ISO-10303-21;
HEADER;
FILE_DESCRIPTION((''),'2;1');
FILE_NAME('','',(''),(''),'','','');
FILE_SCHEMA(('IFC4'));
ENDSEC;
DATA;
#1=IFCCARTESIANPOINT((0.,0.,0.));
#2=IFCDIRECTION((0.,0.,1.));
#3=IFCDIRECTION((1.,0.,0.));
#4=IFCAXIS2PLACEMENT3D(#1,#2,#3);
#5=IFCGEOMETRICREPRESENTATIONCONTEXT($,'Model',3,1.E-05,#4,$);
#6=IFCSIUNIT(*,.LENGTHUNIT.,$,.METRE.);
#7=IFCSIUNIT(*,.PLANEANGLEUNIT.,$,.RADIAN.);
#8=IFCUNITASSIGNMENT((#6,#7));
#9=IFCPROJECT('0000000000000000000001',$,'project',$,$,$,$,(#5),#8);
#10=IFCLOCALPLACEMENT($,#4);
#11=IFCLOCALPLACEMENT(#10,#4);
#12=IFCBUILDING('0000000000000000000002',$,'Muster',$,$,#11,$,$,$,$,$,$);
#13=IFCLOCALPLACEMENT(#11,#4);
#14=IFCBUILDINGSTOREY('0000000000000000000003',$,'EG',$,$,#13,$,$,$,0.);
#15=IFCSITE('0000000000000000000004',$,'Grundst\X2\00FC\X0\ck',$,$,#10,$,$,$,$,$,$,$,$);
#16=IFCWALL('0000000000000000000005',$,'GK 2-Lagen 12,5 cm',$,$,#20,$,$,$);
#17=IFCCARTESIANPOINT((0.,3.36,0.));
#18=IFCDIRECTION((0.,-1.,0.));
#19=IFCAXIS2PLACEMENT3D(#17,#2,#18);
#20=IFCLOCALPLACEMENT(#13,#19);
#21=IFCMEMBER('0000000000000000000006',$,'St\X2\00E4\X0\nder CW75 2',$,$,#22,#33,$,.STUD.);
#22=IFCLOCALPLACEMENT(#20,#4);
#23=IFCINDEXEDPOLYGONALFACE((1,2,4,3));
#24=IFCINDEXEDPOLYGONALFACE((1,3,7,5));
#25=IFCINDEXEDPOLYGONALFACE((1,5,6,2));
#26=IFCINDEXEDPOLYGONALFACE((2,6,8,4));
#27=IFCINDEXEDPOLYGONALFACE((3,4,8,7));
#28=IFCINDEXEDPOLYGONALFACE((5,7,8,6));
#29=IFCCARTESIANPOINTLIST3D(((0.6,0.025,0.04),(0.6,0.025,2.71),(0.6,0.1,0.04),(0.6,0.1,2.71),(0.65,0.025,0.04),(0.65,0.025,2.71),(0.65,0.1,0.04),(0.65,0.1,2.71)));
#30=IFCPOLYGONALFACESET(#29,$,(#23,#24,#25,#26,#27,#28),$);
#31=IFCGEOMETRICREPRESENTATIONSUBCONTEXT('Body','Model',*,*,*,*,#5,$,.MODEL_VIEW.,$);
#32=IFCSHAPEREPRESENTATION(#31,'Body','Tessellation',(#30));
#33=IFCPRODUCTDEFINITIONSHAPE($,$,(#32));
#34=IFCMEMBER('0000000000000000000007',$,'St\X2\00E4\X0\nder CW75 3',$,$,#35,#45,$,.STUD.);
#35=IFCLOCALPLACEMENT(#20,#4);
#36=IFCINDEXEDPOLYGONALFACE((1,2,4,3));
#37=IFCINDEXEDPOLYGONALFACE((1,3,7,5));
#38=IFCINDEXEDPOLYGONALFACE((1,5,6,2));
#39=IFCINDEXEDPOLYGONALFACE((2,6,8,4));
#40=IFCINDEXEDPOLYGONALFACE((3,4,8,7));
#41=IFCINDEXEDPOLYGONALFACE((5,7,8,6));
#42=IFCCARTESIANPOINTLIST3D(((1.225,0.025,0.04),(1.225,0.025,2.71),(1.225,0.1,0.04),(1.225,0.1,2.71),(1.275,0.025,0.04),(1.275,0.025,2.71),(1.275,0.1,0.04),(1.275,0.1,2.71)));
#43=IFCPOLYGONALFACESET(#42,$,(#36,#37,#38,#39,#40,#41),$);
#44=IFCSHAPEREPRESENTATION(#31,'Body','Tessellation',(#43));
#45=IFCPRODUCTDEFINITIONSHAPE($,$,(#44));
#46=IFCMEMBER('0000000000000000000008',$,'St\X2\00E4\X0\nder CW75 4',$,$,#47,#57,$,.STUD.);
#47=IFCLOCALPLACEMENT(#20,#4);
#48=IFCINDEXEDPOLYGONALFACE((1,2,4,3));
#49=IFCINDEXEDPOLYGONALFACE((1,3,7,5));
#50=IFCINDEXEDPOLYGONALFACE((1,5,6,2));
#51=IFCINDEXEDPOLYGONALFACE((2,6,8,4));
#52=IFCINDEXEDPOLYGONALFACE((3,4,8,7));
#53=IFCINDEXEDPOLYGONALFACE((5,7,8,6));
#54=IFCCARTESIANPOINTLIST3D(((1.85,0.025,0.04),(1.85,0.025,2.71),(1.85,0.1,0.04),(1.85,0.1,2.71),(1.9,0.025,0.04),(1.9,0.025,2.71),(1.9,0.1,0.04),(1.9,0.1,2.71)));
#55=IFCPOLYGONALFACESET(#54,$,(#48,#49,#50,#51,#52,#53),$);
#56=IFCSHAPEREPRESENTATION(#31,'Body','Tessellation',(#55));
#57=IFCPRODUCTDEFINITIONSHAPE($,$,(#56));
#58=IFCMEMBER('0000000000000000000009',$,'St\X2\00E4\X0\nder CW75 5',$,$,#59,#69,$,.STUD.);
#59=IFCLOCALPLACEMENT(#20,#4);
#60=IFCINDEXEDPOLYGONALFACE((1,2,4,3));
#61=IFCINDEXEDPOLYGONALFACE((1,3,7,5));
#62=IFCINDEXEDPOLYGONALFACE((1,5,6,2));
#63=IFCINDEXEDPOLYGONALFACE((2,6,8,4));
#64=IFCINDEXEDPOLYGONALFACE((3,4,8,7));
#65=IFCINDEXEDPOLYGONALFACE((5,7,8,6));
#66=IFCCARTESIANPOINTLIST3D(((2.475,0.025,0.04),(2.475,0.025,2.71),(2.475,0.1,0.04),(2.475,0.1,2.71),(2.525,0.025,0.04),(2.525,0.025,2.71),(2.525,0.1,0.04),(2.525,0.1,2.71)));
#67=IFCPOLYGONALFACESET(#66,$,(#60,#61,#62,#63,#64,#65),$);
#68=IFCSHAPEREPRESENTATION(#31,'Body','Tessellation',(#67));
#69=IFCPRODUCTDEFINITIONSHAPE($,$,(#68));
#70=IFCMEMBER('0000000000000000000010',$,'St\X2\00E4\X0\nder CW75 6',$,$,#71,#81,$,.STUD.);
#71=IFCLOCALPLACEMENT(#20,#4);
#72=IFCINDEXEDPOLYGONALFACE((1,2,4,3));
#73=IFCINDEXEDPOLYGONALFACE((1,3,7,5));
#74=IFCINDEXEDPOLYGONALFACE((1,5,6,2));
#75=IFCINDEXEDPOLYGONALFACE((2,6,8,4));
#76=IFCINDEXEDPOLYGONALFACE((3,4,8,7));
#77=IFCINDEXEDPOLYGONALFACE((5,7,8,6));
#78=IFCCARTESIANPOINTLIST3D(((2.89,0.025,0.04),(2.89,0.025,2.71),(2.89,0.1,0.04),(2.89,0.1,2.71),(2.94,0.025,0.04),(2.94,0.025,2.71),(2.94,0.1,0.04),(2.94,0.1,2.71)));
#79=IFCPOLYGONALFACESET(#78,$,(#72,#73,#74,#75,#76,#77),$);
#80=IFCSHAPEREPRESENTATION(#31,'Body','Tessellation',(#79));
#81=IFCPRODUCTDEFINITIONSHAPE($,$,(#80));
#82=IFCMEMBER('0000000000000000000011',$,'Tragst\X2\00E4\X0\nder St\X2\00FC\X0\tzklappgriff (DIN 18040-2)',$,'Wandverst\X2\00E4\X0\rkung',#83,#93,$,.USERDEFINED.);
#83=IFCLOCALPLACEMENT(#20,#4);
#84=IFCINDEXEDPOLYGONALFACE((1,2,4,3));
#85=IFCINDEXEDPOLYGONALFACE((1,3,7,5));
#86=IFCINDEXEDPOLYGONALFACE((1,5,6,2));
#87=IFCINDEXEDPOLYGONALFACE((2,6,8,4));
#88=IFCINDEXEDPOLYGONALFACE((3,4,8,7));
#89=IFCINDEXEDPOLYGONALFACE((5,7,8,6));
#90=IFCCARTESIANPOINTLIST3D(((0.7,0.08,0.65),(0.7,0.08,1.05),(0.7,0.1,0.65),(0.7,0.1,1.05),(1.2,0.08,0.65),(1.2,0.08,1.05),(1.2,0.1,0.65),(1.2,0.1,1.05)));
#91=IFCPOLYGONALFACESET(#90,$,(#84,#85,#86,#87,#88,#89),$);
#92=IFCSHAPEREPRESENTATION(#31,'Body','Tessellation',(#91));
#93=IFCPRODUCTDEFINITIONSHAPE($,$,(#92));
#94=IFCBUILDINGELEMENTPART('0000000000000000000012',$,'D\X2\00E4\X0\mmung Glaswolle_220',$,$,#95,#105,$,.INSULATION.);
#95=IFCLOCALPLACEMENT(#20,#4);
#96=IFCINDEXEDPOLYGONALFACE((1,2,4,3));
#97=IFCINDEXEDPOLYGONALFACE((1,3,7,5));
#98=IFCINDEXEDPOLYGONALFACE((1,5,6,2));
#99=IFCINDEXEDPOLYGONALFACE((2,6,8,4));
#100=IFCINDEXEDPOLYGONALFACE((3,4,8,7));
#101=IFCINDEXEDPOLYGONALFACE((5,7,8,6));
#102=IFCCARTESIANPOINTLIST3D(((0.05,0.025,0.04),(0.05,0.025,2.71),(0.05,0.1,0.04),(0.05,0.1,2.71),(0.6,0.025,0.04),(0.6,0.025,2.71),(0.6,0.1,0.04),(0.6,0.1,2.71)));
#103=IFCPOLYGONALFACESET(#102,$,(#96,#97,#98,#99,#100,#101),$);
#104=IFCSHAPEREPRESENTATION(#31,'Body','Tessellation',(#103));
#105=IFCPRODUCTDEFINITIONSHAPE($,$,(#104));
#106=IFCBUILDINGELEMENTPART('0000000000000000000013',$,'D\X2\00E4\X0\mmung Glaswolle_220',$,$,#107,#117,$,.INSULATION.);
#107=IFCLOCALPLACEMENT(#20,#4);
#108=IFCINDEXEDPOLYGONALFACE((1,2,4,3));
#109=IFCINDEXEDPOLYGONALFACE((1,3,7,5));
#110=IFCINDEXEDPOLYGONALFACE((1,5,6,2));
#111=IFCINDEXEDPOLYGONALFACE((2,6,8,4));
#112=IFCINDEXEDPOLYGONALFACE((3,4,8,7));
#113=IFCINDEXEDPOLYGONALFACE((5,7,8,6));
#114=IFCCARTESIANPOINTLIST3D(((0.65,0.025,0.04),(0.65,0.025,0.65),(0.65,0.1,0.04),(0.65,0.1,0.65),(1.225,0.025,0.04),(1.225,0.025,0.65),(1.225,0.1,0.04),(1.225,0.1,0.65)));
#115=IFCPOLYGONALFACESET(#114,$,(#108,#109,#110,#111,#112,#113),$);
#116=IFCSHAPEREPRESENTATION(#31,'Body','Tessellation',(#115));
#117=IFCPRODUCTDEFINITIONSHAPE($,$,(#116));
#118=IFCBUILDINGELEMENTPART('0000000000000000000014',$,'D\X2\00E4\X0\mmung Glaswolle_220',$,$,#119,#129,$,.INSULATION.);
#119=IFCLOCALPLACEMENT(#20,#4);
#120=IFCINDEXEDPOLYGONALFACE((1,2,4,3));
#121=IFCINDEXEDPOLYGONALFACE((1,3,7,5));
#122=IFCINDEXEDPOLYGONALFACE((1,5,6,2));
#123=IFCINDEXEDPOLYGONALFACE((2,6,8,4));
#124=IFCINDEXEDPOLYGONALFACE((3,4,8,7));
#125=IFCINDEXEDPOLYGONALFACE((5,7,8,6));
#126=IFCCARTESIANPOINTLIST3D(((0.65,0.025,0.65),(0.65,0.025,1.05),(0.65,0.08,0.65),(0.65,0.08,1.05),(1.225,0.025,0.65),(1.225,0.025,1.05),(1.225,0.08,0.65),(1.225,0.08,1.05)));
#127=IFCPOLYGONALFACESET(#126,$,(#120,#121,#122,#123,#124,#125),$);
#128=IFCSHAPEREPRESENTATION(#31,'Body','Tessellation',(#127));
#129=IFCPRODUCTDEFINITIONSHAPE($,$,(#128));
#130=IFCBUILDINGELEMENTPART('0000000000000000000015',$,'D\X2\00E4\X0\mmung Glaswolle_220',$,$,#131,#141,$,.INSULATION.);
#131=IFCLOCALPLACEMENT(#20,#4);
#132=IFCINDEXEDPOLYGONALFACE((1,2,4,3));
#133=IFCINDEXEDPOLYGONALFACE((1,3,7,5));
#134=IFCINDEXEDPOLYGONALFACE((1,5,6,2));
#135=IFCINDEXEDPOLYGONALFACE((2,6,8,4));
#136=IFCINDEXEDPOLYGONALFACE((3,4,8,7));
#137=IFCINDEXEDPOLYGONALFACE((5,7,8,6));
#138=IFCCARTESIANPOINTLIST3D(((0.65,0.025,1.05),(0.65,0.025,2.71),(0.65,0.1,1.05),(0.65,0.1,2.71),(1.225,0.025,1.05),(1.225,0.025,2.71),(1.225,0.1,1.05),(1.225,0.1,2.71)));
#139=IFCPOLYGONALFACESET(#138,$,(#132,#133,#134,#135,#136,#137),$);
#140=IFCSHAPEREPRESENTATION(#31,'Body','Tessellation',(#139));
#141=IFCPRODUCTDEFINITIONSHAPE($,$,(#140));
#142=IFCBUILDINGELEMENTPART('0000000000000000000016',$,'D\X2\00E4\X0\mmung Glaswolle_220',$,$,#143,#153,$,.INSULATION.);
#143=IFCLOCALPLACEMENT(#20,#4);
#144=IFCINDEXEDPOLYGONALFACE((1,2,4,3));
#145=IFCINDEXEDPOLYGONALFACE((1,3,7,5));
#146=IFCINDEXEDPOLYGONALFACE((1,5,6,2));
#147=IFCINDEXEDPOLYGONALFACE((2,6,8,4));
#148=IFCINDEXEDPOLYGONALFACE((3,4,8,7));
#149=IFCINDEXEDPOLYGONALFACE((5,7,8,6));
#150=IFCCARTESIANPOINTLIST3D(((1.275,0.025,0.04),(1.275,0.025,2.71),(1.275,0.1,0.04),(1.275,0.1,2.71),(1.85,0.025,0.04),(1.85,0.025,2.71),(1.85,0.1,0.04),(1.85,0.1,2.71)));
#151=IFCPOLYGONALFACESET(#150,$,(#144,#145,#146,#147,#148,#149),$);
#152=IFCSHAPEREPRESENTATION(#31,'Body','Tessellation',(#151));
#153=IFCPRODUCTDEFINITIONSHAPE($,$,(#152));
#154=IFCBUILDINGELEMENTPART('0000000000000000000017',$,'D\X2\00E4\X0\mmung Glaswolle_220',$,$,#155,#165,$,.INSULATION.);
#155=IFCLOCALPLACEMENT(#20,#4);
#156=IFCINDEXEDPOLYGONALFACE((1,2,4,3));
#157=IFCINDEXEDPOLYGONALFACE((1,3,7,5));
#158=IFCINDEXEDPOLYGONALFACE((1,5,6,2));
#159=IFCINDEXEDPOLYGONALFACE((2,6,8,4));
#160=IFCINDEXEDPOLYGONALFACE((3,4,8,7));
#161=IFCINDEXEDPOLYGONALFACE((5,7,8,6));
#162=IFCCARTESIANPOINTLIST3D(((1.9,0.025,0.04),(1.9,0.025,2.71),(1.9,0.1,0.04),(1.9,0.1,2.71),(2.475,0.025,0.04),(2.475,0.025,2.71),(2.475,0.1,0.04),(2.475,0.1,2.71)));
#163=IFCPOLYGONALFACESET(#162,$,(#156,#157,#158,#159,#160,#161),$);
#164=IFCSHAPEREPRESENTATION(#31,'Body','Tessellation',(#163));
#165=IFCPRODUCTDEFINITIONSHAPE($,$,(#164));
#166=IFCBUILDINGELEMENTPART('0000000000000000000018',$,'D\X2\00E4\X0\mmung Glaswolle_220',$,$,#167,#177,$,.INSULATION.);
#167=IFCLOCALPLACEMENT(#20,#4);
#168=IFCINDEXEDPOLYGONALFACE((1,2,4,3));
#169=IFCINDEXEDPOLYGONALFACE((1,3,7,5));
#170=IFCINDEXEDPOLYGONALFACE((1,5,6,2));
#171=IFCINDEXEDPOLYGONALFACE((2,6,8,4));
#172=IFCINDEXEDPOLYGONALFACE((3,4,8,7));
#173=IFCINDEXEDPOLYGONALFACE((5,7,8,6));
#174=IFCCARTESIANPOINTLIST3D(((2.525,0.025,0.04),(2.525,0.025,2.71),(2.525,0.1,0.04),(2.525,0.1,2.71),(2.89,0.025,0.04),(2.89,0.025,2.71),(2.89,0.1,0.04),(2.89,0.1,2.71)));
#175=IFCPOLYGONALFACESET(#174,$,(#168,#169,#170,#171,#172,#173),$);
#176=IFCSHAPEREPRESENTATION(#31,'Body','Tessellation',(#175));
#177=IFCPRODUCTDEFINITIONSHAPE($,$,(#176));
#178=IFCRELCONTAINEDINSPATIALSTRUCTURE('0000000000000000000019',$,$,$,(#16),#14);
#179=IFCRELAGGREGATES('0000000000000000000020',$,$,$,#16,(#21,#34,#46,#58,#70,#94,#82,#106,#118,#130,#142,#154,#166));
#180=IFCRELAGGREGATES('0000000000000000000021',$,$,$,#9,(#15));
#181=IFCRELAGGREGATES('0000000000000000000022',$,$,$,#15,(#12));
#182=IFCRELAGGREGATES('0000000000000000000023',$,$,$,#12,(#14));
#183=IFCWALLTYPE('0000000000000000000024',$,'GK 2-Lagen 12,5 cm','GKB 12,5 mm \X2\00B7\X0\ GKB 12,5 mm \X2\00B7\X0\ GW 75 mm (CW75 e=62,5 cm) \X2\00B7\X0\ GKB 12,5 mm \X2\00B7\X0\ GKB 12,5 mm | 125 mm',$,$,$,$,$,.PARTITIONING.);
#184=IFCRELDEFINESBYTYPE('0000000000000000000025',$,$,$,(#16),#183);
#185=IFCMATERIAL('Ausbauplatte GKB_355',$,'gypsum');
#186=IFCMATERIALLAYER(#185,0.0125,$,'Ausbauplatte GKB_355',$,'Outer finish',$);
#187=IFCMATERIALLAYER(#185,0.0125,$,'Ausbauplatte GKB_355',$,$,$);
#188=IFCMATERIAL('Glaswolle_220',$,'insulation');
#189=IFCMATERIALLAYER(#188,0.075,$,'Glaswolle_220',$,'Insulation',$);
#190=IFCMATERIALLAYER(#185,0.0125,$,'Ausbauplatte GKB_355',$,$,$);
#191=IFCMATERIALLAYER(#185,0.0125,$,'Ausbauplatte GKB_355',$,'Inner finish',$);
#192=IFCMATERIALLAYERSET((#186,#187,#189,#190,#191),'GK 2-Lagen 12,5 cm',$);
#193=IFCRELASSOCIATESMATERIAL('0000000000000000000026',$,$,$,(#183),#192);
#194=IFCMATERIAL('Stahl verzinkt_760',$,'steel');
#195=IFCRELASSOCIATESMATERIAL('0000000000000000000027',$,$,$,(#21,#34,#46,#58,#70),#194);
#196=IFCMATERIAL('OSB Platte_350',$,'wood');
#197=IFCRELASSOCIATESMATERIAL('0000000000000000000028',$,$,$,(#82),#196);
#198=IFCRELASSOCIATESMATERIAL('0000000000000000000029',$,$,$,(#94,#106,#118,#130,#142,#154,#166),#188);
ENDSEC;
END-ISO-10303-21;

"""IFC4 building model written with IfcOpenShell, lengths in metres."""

from ifc_helpers import new_model, si_unit, frame, frame_2d, origin_with_axes, place, context, subcontext, project, spatial, rectangle, extrude, material, layer, layer_set, type_object, element, aggregate, save


model = new_model("IFC4")

# Units and contexts
model_context = context("Model", 3, precision=1e-05, world=origin_with_axes())
body_context = subcontext(model_context, "Body", "Model", "MODEL_VIEW")
ifc_project = project(units=[si_unit("LENGTHUNIT", "METRE"), si_unit("PLANEANGLEUNIT", "RADIAN")], contexts=[model_context])

# Site, building, storey
site_placement = place(None, origin_with_axes())
site = spatial("IfcSite", under=ifc_project, at=site_placement, Name="Grundstück")
building_placement = place(site_placement, origin_with_axes())
building = spatial("IfcBuilding", under=site, at=building_placement, Name="Muster")
storey_placement = place(building_placement, origin_with_axes())
storey = spatial("IfcBuildingStorey", under=building, at=storey_placement, Name="EG", Elevation=0.0)

# Wall, members
ifc_material_1 = material(Name="Ausbauplatte GKB_355", Category="gypsum")
ifc_layer_1 = layer(ifc_material_1, 0.0125, Name="Ausbauplatte GKB_355", Category="Outer finish")
ifc_layer_2 = layer(ifc_material_1, 0.0125, Name="Ausbauplatte GKB_355")
ifc_material_2 = material(Name="Glaswolle_220", Category="insulation")
ifc_layer_3 = layer(ifc_material_2, 0.075, Name="Glaswolle_220", Category="Insulation")
ifc_layer_4 = layer(ifc_material_1, 0.0125, Name="Ausbauplatte GKB_355")
ifc_layer_5 = layer(ifc_material_1, 0.0125, Name="Ausbauplatte GKB_355", Category="Inner finish")
ifc_layer_set_1 = layer_set([ifc_layer_1, ifc_layer_2, ifc_layer_3, ifc_layer_4, ifc_layer_5], Name="GK 2-Lagen 12,5 cm")
wall_type_1 = type_object("IfcWallType", Name="GK 2-Lagen 12,5 cm", Description="GKB 12,5 mm · GKB 12,5 mm · GW 75 mm (CW75 e=62,5 cm) · GKB 12,5 mm · GKB 12,5 mm | 125 mm", PredefinedType="PARTITIONING", material=ifc_layer_set_1)
wall_1_placement = place(storey_placement, frame((0.0, 3.36, 0.0), z_axis=(0.0, 0.0, 1.0), x_axis=(0.0, -1.0, 0.0)))
wall_1 = element("IfcWall", 1, at=wall_1_placement, inside=storey, type_object=wall_type_1, Name="GK 2-Lagen 12,5 cm")
ifc_material_3 = material(Name="Stahl verzinkt_760", Category="steel")
member_1_placement = place(wall_1_placement, origin_with_axes())
member_1 = element("IfcMember", 2, at=member_1_placement, material=ifc_material_3, Name="Ständer CW75 2", PredefinedType="STUD", context=body_context, shape_type="SweptSolid", body=[
    extrude(rectangle(XDim=0.05, YDim=0.075, at=frame_2d((0.625, 0.0625))), frame((0.0, 0.0, 0.04)), (0.0, 0.0, 1.0), 2.67),
])
member_2_placement = place(wall_1_placement, origin_with_axes())
member_2 = element("IfcMember", 3, at=member_2_placement, material=ifc_material_3, Name="Ständer CW75 3", PredefinedType="STUD", context=body_context, shape_type="SweptSolid", body=[
    extrude(rectangle(XDim=0.05, YDim=0.075, at=frame_2d((1.25, 0.0625))), frame((0.0, 0.0, 0.04)), (0.0, 0.0, 1.0), 2.67),
])
member_3_placement = place(wall_1_placement, origin_with_axes())
member_3 = element("IfcMember", 4, at=member_3_placement, material=ifc_material_3, Name="Ständer CW75 4", PredefinedType="STUD", context=body_context, shape_type="SweptSolid", body=[
    extrude(rectangle(XDim=0.05, YDim=0.075, at=frame_2d((1.875, 0.0625))), frame((0.0, 0.0, 0.04)), (0.0, 0.0, 1.0), 2.67),
])
member_4_placement = place(wall_1_placement, origin_with_axes())
member_4 = element("IfcMember", 5, at=member_4_placement, material=ifc_material_3, Name="Ständer CW75 5", PredefinedType="STUD", context=body_context, shape_type="SweptSolid", body=[
    extrude(rectangle(XDim=0.05, YDim=0.075, at=frame_2d((2.5, 0.0625))), frame((0.0, 0.0, 0.04)), (0.0, 0.0, 1.0), 2.67),
])
member_5_placement = place(wall_1_placement, origin_with_axes())
member_5 = element("IfcMember", 6, at=member_5_placement, material=ifc_material_3, Name="Ständer CW75 6", PredefinedType="STUD", context=body_context, shape_type="SweptSolid", body=[
    extrude(rectangle(XDim=0.05, YDim=0.075, at=frame_2d((2.915, 0.0625))), frame((0.0, 0.0, 0.04)), (0.0, 0.0, 1.0), 2.67),
])
ifc_material_4 = material(Name="OSB Platte_350", Category="wood")
member_6_placement = place(wall_1_placement, origin_with_axes())
member_6 = element("IfcMember", 7, at=member_6_placement, material=ifc_material_4, Name="Tragständer Stützklappgriff (DIN 18040-2)", ObjectType="Wandverstärkung", PredefinedType="USERDEFINED", context=body_context, shape_type="SweptSolid", body=[
    extrude(rectangle(XDim=0.5, YDim=0.02, at=frame_2d((0.95, 0.09))), frame((0.0, 0.0, 0.65)), (0.0, 0.0, 1.0), 0.4),
])

# Building element parts
building_element_part_1_placement = place(wall_1_placement, origin_with_axes())
building_element_part_1 = element("IfcBuildingElementPart", 8, at=building_element_part_1_placement, material=ifc_material_2, Name="Dämmung Glaswolle_220", PredefinedType="INSULATION", context=body_context, shape_type="SweptSolid", body=[
    extrude(rectangle(XDim=0.55, YDim=0.075, at=frame_2d((0.325, 0.0625))), frame((0.0, 0.0, 0.04)), (0.0, 0.0, 1.0), 2.67),
])
building_element_part_2_placement = place(wall_1_placement, origin_with_axes())
building_element_part_2 = element("IfcBuildingElementPart", 9, at=building_element_part_2_placement, material=ifc_material_2, Name="Dämmung Glaswolle_220", PredefinedType="INSULATION", context=body_context, shape_type="SweptSolid", body=[
    extrude(rectangle(XDim=0.575, YDim=0.075, at=frame_2d((0.9375, 0.0625))), frame((0.0, 0.0, 0.04)), (0.0, 0.0, 1.0), 0.61),
])
building_element_part_3_placement = place(wall_1_placement, origin_with_axes())
building_element_part_3 = element("IfcBuildingElementPart", 10, at=building_element_part_3_placement, material=ifc_material_2, Name="Dämmung Glaswolle_220", PredefinedType="INSULATION", context=body_context, shape_type="SweptSolid", body=[
    extrude(rectangle(XDim=0.575, YDim=0.055, at=frame_2d((0.9375, 0.0525))), frame((0.0, 0.0, 0.65)), (0.0, 0.0, 1.0), 0.4),
])
building_element_part_4_placement = place(wall_1_placement, origin_with_axes())
building_element_part_4 = element("IfcBuildingElementPart", 11, at=building_element_part_4_placement, material=ifc_material_2, Name="Dämmung Glaswolle_220", PredefinedType="INSULATION", context=body_context, shape_type="SweptSolid", body=[
    extrude(rectangle(XDim=0.575, YDim=0.075, at=frame_2d((0.9375, 0.0625))), frame((0.0, 0.0, 1.05)), (0.0, 0.0, 1.0), 1.66),
])
building_element_part_5_placement = place(wall_1_placement, origin_with_axes())
building_element_part_5 = element("IfcBuildingElementPart", 12, at=building_element_part_5_placement, material=ifc_material_2, Name="Dämmung Glaswolle_220", PredefinedType="INSULATION", context=body_context, shape_type="SweptSolid", body=[
    extrude(rectangle(XDim=0.575, YDim=0.075, at=frame_2d((1.5625, 0.0625))), frame((0.0, 0.0, 0.04)), (0.0, 0.0, 1.0), 2.67),
])
building_element_part_6_placement = place(wall_1_placement, origin_with_axes())
building_element_part_6 = element("IfcBuildingElementPart", 13, at=building_element_part_6_placement, material=ifc_material_2, Name="Dämmung Glaswolle_220", PredefinedType="INSULATION", context=body_context, shape_type="SweptSolid", body=[
    extrude(rectangle(XDim=0.575, YDim=0.075, at=frame_2d((2.1875, 0.0625))), frame((0.0, 0.0, 0.04)), (0.0, 0.0, 1.0), 2.67),
])
building_element_part_7_placement = place(wall_1_placement, origin_with_axes())
building_element_part_7 = element("IfcBuildingElementPart", 14, at=building_element_part_7_placement, material=ifc_material_2, Name="Dämmung Glaswolle_220", PredefinedType="INSULATION", context=body_context, shape_type="SweptSolid", body=[
    extrude(rectangle(XDim=0.365, YDim=0.075, at=frame_2d((2.7075, 0.0625))), frame((0.0, 0.0, 0.04)), (0.0, 0.0, 1.0), 2.67),
])
aggregate(wall_1, [member_1, member_2, member_3, member_4, member_5, building_element_part_1, member_6, building_element_part_2, building_element_part_3, building_element_part_4, building_element_part_5, building_element_part_6, building_element_part_7])

save(model, "model.ifc")
